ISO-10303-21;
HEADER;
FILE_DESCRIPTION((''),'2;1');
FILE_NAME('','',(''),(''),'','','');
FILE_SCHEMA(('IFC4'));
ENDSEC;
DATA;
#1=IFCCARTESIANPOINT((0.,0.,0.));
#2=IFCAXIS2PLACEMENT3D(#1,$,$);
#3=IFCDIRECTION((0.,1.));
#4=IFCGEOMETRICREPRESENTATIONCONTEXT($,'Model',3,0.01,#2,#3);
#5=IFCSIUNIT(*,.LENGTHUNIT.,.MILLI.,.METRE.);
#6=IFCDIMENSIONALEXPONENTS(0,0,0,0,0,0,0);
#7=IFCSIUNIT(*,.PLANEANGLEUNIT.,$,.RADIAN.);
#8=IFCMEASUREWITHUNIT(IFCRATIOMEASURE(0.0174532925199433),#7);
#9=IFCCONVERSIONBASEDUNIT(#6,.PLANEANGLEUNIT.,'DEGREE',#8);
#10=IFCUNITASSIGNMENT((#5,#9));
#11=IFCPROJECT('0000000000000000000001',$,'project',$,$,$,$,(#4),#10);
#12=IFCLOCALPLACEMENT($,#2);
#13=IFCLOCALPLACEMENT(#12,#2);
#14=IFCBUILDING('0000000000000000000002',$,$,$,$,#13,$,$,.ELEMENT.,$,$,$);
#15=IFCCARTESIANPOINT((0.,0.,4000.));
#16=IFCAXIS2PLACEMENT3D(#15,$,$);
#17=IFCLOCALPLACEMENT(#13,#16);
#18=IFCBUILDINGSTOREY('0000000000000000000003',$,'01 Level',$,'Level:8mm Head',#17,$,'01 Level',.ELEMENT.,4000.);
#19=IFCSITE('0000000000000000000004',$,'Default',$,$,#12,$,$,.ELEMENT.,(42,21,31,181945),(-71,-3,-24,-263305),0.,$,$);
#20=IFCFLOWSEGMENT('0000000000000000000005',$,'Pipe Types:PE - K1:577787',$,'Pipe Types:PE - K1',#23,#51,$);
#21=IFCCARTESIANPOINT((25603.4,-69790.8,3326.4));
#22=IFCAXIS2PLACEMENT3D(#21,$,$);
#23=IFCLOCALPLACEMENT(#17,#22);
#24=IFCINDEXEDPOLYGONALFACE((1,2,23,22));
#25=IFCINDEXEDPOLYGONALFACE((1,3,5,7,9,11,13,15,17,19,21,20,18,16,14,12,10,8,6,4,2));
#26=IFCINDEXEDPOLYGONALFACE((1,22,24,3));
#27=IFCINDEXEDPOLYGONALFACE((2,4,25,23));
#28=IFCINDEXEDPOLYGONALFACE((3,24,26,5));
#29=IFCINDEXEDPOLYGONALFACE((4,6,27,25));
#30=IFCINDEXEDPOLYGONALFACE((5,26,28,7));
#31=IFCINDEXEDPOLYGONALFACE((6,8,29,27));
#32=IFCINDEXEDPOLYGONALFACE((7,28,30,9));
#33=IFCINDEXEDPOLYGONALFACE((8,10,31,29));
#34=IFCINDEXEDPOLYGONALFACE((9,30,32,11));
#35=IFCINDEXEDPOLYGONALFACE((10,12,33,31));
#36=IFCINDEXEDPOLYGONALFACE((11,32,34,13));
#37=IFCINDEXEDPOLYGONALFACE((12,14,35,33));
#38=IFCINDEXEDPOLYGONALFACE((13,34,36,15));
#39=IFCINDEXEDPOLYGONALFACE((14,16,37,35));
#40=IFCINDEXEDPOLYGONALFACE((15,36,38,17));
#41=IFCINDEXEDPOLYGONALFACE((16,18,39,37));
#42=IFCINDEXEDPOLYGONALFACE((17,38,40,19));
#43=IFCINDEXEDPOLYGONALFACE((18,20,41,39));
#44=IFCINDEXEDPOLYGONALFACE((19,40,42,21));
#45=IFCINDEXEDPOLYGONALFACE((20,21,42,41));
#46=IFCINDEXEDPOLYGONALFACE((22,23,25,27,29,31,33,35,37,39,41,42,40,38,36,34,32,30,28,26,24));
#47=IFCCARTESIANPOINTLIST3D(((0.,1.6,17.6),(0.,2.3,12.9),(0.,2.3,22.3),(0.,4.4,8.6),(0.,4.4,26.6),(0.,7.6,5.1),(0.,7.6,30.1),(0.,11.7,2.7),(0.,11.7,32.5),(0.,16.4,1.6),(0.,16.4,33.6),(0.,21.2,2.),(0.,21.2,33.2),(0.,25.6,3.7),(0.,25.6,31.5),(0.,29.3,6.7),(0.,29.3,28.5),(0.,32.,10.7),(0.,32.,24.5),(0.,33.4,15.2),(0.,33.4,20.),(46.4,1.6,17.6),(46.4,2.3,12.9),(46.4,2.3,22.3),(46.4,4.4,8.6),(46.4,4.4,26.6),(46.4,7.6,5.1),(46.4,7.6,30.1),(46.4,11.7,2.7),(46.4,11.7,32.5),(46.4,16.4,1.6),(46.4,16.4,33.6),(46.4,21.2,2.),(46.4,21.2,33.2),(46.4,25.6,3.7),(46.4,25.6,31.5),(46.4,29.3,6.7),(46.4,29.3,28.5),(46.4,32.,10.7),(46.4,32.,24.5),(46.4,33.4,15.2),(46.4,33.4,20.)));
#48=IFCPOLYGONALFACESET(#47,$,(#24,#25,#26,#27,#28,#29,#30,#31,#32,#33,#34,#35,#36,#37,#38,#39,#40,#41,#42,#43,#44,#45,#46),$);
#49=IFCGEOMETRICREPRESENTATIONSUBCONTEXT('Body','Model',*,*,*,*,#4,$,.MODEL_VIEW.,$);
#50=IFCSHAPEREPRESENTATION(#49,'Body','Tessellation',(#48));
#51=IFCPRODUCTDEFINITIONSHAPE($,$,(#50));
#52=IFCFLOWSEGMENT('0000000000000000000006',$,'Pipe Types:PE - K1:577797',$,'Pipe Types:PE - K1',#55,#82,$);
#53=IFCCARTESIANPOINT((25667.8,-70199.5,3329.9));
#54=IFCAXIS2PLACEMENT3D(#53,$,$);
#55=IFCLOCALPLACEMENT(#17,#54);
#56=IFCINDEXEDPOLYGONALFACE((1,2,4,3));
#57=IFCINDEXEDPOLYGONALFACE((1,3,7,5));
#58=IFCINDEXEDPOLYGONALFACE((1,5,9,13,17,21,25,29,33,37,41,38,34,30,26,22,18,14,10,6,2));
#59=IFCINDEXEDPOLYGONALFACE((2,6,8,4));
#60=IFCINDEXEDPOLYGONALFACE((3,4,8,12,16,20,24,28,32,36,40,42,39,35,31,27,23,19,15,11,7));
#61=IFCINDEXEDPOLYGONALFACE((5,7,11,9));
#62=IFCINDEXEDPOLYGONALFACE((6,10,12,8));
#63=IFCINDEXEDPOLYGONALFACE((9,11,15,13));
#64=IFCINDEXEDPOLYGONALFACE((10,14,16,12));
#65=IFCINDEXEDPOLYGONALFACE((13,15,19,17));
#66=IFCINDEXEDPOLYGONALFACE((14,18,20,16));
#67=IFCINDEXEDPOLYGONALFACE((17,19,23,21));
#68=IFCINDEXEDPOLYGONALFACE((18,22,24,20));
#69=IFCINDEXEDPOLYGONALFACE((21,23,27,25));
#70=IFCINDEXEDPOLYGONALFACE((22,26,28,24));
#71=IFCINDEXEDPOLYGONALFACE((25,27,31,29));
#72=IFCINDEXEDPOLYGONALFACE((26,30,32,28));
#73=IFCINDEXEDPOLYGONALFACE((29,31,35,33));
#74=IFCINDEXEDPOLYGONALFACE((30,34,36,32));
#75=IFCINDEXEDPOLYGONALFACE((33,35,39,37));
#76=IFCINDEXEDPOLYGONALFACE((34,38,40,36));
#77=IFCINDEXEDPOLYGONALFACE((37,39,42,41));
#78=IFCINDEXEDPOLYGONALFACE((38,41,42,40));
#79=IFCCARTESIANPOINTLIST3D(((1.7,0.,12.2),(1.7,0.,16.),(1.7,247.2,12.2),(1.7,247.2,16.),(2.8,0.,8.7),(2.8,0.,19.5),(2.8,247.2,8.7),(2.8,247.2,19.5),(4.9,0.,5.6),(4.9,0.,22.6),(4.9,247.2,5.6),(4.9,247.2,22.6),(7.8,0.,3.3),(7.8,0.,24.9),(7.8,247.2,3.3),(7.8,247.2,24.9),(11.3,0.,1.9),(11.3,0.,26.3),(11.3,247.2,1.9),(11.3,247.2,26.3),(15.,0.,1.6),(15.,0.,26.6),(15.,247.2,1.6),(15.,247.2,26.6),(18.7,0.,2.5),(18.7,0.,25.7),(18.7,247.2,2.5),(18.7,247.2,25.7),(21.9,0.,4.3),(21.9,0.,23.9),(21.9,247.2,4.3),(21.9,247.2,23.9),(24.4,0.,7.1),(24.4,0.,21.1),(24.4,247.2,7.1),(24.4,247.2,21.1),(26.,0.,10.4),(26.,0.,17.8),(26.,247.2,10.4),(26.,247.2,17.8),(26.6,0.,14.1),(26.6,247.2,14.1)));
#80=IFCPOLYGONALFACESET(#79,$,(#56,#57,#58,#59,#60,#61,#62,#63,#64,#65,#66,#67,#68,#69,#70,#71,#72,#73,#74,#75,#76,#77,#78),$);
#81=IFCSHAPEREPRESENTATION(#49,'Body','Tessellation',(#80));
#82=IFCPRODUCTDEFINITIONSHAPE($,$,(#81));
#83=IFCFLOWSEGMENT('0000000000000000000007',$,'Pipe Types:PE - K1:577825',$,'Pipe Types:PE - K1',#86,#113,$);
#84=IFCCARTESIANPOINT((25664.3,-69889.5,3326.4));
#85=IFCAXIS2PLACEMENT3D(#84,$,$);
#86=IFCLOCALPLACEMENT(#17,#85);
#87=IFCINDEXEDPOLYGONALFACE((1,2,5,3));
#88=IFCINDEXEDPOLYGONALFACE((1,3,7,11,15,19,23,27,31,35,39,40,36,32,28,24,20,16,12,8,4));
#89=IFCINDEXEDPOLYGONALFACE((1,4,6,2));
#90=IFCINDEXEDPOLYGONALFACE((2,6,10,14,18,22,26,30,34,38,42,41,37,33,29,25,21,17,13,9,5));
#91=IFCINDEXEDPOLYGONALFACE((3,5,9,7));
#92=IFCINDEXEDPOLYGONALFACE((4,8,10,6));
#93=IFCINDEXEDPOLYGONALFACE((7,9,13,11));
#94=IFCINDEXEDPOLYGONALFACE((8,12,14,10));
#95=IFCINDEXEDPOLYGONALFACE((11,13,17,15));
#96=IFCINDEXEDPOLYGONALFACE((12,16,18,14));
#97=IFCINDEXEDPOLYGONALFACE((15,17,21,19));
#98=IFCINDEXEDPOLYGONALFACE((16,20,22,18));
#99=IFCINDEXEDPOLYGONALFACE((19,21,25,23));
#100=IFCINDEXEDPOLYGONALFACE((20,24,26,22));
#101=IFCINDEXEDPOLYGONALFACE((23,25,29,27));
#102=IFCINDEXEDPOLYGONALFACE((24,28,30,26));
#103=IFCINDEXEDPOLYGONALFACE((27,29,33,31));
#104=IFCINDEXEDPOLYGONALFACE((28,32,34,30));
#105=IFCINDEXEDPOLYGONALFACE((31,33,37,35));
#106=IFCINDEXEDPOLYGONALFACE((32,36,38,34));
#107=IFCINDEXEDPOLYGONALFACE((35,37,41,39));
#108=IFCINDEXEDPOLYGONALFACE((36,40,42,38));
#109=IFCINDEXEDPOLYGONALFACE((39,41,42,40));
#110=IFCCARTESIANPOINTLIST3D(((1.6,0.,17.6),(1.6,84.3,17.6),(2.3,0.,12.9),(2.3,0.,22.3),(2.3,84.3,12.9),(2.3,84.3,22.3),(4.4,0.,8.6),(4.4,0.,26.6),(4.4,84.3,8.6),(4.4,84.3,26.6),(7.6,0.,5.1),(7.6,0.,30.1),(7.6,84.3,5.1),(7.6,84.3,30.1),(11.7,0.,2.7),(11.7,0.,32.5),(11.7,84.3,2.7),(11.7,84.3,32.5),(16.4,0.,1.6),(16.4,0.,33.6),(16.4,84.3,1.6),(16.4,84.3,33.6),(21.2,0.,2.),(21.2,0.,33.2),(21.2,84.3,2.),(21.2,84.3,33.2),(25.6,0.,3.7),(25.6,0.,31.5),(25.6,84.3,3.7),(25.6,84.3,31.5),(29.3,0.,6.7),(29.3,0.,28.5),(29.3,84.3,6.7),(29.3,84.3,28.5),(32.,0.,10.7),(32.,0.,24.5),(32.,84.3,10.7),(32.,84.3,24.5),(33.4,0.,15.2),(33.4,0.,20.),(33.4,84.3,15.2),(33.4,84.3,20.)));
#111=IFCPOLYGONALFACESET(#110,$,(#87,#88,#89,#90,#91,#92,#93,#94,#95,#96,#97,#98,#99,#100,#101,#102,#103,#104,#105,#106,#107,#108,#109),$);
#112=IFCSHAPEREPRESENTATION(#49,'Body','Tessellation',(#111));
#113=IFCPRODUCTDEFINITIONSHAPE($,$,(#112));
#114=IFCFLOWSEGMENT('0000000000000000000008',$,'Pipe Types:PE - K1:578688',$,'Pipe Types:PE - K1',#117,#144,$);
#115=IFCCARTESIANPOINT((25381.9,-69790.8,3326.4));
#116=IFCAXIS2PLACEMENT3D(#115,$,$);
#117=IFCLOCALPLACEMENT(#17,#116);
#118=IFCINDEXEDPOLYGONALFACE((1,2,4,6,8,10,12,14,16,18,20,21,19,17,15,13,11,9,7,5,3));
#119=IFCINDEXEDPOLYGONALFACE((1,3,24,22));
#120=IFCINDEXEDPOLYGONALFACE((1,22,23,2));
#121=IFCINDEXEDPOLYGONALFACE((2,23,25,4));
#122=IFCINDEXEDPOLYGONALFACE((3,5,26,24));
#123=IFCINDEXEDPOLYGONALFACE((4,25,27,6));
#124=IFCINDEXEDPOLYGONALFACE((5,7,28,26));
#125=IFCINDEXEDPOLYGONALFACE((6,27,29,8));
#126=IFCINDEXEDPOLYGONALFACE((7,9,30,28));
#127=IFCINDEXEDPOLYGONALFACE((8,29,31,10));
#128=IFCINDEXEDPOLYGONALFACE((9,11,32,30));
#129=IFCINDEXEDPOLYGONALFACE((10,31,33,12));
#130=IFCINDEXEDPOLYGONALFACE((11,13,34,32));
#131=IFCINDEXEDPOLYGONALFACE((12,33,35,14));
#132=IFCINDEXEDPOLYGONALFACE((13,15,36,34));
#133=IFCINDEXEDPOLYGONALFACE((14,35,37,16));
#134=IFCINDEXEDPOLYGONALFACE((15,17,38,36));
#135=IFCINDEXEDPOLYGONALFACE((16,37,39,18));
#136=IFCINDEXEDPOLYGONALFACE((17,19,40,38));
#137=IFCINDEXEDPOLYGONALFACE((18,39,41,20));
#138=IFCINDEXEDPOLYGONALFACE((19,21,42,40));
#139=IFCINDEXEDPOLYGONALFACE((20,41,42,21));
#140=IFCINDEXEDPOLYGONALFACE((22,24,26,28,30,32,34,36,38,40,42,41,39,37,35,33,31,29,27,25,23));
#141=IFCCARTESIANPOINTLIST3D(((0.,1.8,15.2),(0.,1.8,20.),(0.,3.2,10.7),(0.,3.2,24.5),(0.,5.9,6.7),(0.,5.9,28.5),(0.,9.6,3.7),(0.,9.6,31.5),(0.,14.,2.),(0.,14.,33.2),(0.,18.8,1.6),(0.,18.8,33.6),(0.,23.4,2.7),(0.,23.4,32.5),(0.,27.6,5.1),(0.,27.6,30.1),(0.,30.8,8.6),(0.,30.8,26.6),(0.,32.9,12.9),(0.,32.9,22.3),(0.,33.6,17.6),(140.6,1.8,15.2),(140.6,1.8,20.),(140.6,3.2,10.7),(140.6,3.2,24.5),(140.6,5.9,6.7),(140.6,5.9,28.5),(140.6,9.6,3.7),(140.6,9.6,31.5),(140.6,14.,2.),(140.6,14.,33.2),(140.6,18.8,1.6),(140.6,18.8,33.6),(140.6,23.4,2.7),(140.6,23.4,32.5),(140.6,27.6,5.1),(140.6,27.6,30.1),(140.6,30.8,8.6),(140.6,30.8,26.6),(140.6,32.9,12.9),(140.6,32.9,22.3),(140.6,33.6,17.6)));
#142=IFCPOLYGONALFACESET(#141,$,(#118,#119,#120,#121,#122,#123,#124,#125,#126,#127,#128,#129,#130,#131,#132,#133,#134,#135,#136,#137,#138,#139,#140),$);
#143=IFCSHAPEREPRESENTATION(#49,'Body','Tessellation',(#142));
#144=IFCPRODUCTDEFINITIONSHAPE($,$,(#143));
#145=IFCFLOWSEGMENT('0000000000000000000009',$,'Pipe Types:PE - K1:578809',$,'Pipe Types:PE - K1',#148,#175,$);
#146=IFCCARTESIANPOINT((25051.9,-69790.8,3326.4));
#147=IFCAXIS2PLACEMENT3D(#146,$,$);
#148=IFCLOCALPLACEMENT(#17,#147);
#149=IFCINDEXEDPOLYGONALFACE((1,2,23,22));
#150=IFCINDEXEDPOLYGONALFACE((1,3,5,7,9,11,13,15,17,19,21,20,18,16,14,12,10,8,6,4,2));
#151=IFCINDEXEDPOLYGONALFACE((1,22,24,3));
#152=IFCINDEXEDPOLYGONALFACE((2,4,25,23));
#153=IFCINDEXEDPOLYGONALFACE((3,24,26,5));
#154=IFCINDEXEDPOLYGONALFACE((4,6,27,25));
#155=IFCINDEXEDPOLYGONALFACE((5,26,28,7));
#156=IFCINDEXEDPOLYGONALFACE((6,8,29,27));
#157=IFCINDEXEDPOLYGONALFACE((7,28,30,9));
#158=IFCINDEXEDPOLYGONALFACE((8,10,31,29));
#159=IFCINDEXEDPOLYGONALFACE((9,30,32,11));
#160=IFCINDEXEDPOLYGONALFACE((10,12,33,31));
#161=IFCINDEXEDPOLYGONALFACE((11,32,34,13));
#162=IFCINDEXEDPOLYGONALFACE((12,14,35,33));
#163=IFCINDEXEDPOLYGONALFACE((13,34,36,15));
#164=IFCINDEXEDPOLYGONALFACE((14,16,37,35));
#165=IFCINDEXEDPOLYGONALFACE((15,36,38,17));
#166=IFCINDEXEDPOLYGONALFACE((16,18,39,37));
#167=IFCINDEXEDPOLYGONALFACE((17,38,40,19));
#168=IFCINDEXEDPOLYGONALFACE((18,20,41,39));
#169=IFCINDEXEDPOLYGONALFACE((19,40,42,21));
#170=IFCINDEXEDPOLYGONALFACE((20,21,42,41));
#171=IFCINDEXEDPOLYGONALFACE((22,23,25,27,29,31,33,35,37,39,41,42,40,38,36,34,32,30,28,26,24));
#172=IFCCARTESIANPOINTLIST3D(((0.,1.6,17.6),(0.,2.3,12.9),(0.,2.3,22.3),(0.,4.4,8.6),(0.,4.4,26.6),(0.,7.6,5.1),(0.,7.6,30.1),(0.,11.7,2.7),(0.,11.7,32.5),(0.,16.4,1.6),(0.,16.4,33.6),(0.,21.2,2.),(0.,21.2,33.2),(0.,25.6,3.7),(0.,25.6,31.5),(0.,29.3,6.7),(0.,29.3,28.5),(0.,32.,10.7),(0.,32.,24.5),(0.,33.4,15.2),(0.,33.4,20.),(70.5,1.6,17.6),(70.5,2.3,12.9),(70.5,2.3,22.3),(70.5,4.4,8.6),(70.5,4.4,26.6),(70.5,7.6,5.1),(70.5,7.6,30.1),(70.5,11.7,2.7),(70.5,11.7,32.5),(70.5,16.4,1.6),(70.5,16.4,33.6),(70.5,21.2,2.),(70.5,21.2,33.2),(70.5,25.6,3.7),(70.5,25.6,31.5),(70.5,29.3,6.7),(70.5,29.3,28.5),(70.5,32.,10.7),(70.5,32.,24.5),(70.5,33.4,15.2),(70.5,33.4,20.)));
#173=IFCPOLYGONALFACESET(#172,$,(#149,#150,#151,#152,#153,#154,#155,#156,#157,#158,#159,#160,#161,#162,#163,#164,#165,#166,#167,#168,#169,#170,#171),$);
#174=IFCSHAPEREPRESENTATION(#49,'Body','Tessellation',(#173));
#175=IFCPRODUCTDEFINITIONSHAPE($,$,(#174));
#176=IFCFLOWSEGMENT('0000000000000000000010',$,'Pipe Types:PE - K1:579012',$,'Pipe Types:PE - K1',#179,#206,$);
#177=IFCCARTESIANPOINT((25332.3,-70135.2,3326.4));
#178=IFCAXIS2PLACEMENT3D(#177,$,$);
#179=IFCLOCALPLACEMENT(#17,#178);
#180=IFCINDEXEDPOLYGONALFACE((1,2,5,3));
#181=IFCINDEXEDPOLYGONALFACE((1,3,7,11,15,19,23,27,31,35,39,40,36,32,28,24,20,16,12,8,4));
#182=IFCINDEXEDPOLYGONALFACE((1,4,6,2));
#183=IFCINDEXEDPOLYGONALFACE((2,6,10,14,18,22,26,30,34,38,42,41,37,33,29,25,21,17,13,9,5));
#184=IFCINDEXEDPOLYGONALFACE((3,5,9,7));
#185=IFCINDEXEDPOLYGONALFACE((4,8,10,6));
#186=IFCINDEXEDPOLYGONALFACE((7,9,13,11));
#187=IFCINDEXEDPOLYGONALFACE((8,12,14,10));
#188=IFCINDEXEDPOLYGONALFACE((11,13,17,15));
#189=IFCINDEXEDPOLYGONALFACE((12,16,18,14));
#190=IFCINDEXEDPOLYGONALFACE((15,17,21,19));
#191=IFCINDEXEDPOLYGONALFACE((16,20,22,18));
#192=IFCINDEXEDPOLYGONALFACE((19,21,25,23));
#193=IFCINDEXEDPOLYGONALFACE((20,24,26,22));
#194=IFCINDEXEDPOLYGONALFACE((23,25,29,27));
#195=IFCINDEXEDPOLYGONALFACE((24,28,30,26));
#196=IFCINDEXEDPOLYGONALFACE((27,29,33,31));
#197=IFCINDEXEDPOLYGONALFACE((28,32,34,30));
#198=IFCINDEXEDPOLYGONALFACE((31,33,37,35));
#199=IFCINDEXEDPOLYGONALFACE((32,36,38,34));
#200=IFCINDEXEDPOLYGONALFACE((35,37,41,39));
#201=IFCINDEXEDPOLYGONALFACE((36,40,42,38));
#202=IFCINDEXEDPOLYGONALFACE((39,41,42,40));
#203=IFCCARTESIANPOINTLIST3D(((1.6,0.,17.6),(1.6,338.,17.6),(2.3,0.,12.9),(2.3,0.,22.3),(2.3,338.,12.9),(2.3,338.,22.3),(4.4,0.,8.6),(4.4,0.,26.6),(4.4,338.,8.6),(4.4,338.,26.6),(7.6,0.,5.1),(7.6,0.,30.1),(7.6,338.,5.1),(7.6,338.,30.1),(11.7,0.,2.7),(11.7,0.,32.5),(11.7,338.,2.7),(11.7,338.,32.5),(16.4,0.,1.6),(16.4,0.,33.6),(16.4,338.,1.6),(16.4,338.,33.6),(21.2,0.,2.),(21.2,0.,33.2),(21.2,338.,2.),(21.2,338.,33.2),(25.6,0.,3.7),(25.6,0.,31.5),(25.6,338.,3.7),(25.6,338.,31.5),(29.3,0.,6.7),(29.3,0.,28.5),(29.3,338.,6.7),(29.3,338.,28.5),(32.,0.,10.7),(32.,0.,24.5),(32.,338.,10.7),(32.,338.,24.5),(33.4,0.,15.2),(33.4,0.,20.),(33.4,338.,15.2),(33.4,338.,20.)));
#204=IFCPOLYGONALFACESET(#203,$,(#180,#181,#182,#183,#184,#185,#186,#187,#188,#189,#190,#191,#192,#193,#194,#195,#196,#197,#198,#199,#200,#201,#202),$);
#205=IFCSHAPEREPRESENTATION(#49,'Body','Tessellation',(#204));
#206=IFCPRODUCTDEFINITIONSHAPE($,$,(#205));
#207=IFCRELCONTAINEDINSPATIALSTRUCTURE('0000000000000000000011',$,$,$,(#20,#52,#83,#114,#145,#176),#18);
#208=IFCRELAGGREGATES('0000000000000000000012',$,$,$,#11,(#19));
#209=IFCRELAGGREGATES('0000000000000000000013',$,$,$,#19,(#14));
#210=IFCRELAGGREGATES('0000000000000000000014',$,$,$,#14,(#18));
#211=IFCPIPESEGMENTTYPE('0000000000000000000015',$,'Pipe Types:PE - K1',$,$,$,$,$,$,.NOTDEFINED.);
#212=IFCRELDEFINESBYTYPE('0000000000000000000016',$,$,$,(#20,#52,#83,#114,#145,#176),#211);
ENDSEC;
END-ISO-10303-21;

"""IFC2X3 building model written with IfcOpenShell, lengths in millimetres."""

from ifc_helpers import new_model, entity, si_unit, converted_unit, direction, frame, frame_2d, origin, origin_2d_with_axis, place, context, subcontext, project, spatial, circle, extrude, type_object, element, save


model = new_model("IFC2X3")

# Units and contexts
model_context = context("Model", 3, precision=0.01, world=origin(), true_north=direction((0.0, 1.0)))
body_context = subcontext(model_context, "Body", "Model", "MODEL_VIEW")
ifc_project = project(units=[si_unit("LENGTHUNIT", "METRE", prefix="MILLI"), converted_unit("PLANEANGLEUNIT", "DEGREE", entity("IfcRatioMeasure", 0.0174532925199433), si_unit("PLANEANGLEUNIT", "RADIAN"), dimensions=[0, 0, 0, 0, 0, 0, 0])], contexts=[model_context])

# Site, building, storey
site_placement = place(None, origin())
site = spatial("IfcSite", under=ifc_project, at=site_placement, Name="Default", CompositionType="ELEMENT", RefLatitude=(42, 21, 31, 181945), RefLongitude=(-71, -3, -24, -263305), RefElevation=0.0)
building_placement = place(site_placement, origin())
building = spatial("IfcBuilding", under=site, at=building_placement, CompositionType="ELEMENT")
storey_placement = place(building_placement, frame((0.0, 0.0, 4000.0)))
storey = spatial("IfcBuildingStorey", under=building, at=storey_placement, Name="01 Level", ObjectType="Level:8mm Head", LongName="01 Level", CompositionType="ELEMENT", Elevation=4000.0)

# Flow segments
pipe_segment_type = type_object("IfcPipeSegmentType", Name="Pipe Types:PE - K1", PredefinedType="NOTDEFINED")
flow_segment_1_placement = place(storey_placement, frame((25603.4, -69790.8, 3326.4)))
element("IfcFlowSegment", 1, at=flow_segment_1_placement, inside=storey, type_object=pipe_segment_type, Name="Pipe Types:PE - K1:577787", ObjectType="Pipe Types:PE - K1", context=body_context, shape_type="SweptSolid", body=[
    extrude(circle(Radius=16.0, at=origin_2d_with_axis()), frame((0.0, 17.6, 17.6), z_axis=(1.0, 0.0, 0.0), x_axis=(0.0, -1.0, 0.0)), (0.0, 0.0, 1.0), 46.4),
])
flow_segment_2_placement = place(storey_placement, frame((25667.8, -70199.5, 3329.9)))
element("IfcFlowSegment", 2, at=flow_segment_2_placement, inside=storey, type_object=pipe_segment_type, Name="Pipe Types:PE - K1:577797", ObjectType="Pipe Types:PE - K1", context=body_context, shape_type="SweptSolid", body=[
    extrude(circle(Radius=12.5, at=origin_2d_with_axis()), frame((14.1, 0.0, 14.1), z_axis=(0.0, 1.0, 0.0), x_axis=(1.0, 0.0, 0.0)), (0.0, 0.0, 1.0), 247.2),
])
flow_segment_3_placement = place(storey_placement, frame((25664.3, -69889.5, 3326.4)))
element("IfcFlowSegment", 3, at=flow_segment_3_placement, inside=storey, type_object=pipe_segment_type, Name="Pipe Types:PE - K1:577825", ObjectType="Pipe Types:PE - K1", context=body_context, shape_type="SweptSolid", body=[
    extrude(circle(Radius=16.0, at=origin_2d_with_axis()), frame((17.6, 0.0, 17.6), z_axis=(0.0, 1.0, 0.0), x_axis=(-1.0, 0.0, 0.0)), (0.0, 0.0, 1.0), 84.3),
])
flow_segment_4_placement = place(storey_placement, frame((25381.9, -69790.8, 3326.4)))
element("IfcFlowSegment", 4, at=flow_segment_4_placement, inside=storey, type_object=pipe_segment_type, Name="Pipe Types:PE - K1:578688", ObjectType="Pipe Types:PE - K1", context=body_context, shape_type="SweptSolid", body=[
    extrude(circle(Radius=16.0, at=frame_2d((0.0, 0.0), x_axis=(1.0, 0.0))), frame((0.0, 17.6, 17.6), z_axis=(1.0, 0.0, 0.0), x_axis=(0.0, 1.0, 0.0)), (0.0, 0.0, 1.0), 140.6),
])
flow_segment_5_placement = place(storey_placement, frame((25051.9, -69790.8, 3326.4)))
element("IfcFlowSegment", 5, at=flow_segment_5_placement, inside=storey, type_object=pipe_segment_type, Name="Pipe Types:PE - K1:578809", ObjectType="Pipe Types:PE - K1", context=body_context, shape_type="SweptSolid", body=[
    extrude(circle(Radius=16.0, at=origin_2d_with_axis()), frame((0.0, 17.6, 17.6), z_axis=(1.0, 0.0, 0.0), x_axis=(0.0, -1.0, 0.0)), (0.0, 0.0, 1.0), 70.5),
])
flow_segment_6_placement = place(storey_placement, frame((25332.3, -70135.2, 3326.4)))
element("IfcFlowSegment", 6, at=flow_segment_6_placement, inside=storey, type_object=pipe_segment_type, Name="Pipe Types:PE - K1:579012", ObjectType="Pipe Types:PE - K1", context=body_context, shape_type="SweptSolid", body=[
    extrude(circle(Radius=16.0, at=frame_2d((0.0, 0.0), x_axis=(1.0, 0.0))), frame((17.6, 0.0, 17.6), z_axis=(0.0, 1.0, 0.0), x_axis=(-1.0, 0.0, 0.0)), (0.0, 0.0, 1.0), 338.0),
])

save(model, "model.ifc")
